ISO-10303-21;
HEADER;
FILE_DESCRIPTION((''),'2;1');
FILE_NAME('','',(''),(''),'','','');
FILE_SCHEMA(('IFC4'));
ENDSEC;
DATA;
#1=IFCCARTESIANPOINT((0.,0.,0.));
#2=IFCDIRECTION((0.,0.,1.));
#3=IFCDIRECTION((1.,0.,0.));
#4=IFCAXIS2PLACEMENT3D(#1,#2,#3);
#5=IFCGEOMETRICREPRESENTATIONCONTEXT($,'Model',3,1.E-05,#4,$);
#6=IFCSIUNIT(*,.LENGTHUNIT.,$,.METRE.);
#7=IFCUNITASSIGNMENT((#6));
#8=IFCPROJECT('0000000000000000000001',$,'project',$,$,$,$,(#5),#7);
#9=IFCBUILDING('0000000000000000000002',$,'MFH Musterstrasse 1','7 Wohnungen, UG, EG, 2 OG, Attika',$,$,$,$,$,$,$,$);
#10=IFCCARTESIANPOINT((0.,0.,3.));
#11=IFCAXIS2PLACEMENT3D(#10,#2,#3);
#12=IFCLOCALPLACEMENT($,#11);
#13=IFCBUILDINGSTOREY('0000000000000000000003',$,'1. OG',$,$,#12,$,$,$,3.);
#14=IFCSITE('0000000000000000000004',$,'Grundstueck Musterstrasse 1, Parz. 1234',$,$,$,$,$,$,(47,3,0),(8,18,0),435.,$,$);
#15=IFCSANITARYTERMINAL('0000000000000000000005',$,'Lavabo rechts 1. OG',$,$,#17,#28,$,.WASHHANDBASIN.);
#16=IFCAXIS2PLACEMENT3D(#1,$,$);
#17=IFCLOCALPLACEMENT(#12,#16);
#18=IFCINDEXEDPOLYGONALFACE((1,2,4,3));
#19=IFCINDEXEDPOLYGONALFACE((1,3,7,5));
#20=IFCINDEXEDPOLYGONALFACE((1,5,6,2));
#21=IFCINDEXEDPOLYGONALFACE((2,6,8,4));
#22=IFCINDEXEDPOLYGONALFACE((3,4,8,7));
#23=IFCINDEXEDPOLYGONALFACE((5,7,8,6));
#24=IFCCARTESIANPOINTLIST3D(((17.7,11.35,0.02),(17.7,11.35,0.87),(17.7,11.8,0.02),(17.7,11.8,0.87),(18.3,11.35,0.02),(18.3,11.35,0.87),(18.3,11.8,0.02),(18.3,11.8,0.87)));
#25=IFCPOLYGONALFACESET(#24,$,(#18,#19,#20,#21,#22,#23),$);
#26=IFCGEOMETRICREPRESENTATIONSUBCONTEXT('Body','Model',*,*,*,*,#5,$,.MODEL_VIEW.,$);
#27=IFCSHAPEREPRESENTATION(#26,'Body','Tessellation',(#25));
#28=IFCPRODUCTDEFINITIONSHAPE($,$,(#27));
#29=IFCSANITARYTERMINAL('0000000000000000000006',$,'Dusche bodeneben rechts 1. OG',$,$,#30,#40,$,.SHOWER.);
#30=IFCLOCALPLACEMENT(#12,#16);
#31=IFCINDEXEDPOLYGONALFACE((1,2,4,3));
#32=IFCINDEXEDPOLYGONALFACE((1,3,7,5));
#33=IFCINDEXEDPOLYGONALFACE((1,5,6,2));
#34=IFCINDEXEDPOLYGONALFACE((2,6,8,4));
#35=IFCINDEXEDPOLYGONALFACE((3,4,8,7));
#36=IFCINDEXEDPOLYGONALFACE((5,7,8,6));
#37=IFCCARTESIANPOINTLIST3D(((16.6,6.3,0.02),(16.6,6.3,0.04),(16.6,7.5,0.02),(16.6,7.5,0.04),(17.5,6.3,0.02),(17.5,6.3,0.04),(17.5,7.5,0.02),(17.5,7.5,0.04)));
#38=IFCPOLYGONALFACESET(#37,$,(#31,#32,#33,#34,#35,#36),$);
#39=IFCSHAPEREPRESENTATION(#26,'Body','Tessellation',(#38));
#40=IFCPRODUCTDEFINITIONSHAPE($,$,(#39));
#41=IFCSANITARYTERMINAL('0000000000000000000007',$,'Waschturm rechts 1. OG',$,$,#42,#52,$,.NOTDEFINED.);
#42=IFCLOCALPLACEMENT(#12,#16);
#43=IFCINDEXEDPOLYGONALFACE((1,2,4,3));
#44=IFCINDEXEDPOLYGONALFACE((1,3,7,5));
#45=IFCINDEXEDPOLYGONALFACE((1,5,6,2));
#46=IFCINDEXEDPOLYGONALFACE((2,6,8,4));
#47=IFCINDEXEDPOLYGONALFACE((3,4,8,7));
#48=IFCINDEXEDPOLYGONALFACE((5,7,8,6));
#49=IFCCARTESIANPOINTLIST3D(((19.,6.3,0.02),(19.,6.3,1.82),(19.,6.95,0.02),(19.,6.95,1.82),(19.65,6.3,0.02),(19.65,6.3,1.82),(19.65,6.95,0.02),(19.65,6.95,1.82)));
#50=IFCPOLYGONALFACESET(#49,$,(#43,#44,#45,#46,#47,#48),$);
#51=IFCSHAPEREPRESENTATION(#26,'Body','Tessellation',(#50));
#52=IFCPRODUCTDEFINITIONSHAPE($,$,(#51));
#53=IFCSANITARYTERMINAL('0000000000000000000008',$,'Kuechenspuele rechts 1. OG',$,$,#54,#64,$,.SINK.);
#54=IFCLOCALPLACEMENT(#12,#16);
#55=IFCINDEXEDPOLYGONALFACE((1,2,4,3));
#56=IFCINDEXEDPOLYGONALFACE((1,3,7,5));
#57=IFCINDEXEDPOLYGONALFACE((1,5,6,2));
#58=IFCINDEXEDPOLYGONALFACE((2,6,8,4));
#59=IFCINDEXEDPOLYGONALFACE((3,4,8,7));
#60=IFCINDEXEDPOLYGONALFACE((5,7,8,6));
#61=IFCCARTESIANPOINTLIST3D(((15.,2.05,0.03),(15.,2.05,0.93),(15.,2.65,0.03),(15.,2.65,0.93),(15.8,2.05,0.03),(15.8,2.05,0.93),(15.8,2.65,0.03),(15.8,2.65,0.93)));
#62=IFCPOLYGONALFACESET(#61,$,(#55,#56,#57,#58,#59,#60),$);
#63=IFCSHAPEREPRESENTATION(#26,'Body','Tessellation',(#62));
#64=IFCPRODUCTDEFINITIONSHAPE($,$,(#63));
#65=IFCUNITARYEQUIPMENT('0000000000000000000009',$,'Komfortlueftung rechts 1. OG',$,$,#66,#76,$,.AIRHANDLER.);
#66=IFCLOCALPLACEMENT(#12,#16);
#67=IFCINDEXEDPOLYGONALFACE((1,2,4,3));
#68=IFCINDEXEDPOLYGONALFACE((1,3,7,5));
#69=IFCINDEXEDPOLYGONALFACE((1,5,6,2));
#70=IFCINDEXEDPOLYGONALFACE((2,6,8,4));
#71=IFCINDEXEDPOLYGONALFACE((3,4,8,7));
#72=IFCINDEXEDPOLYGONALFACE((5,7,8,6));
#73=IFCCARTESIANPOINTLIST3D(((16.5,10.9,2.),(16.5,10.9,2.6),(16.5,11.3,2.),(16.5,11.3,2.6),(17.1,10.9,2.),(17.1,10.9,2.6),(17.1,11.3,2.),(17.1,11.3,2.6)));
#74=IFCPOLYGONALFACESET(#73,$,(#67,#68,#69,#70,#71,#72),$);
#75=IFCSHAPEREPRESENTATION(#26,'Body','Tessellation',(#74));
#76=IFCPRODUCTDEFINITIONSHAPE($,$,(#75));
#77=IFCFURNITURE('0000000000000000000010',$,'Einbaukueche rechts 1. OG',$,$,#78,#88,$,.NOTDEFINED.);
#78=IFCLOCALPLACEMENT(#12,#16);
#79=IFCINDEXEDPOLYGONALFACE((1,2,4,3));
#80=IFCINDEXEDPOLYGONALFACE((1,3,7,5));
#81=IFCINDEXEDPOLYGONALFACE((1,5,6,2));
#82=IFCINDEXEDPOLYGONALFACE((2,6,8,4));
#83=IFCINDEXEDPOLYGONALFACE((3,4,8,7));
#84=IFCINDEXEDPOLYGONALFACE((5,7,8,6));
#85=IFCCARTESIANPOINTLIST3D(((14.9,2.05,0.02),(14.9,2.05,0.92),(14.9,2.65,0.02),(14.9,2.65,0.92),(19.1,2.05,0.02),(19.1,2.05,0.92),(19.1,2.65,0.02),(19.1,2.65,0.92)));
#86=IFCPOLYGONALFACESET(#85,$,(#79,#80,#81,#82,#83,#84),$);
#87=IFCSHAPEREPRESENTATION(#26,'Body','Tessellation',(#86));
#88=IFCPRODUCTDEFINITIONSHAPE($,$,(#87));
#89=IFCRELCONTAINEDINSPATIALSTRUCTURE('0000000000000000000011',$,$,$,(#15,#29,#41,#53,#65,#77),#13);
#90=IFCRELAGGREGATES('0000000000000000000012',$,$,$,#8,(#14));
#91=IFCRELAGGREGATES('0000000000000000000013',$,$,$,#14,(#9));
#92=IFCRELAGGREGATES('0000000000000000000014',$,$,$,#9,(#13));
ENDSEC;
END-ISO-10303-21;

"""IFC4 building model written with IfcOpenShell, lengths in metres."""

from ifc_helpers import new_model, si_unit, frame, frame_2d, origin_with_axes, place, context, subcontext, project, spatial, rectangle, extrude, element, save


model = new_model("IFC4")

# Units and contexts
model_context = context("Model", 3, precision=1e-05, world=origin_with_axes())
body_context = subcontext(model_context, "Body", "Model", "MODEL_VIEW")
ifc_project = project(units=[si_unit("LENGTHUNIT", "METRE")], contexts=[model_context])

# Site, building, storey
site = spatial("IfcSite", under=ifc_project, Name="Grundstueck Musterstrasse 1, Parz. 1234", RefLatitude=(47, 3, 0), RefLongitude=(8, 18, 0), RefElevation=435.0)
building = spatial("IfcBuilding", under=site, Name="MFH Musterstrasse 1", Description="7 Wohnungen, UG, EG, 2 OG, Attika")
storey_placement = place(None, frame((0.0, 0.0, 3.0), z_axis=(0.0, 0.0, 1.0), x_axis=(1.0, 0.0, 0.0)))
storey = spatial("IfcBuildingStorey", under=building, at=storey_placement, Name="1. OG", Elevation=3.0)

# Sanitary terminals
sanitary_terminal_1_placement = place(storey_placement, frame((17.7, 11.35, 0.02), z_axis=(0.0, 0.0, 1.0), x_axis=(1.0, 0.0, 0.0)))
element("IfcSanitaryTerminal", 1, at=sanitary_terminal_1_placement, inside=storey, Name="Lavabo rechts 1. OG", PredefinedType="WASHHANDBASIN", context=body_context, shape_type="SweptSolid", body=[
    extrude(rectangle(XDim=0.6, YDim=0.45, at=frame_2d((0.3, 0.225))), origin_with_axes(), (0.0, 0.0, 1.0), 0.85),
])
sanitary_terminal_2_placement = place(storey_placement, frame((16.6, 6.3, 0.02), z_axis=(0.0, 0.0, 1.0), x_axis=(1.0, 0.0, 0.0)))
element("IfcSanitaryTerminal", 2, at=sanitary_terminal_2_placement, inside=storey, Name="Dusche bodeneben rechts 1. OG", PredefinedType="SHOWER", context=body_context, shape_type="SweptSolid", body=[
    extrude(rectangle(XDim=0.9, YDim=1.2, at=frame_2d((0.45, 0.6))), origin_with_axes(), (0.0, 0.0, 1.0), 0.02),
])
sanitary_terminal_3_placement = place(storey_placement, frame((19.0, 6.3, 0.02), z_axis=(0.0, 0.0, 1.0), x_axis=(1.0, 0.0, 0.0)))
element("IfcSanitaryTerminal", 3, at=sanitary_terminal_3_placement, inside=storey, Name="Waschturm rechts 1. OG", PredefinedType="NOTDEFINED", context=body_context, shape_type="SweptSolid", body=[
    extrude(rectangle(XDim=0.65, YDim=0.65, at=frame_2d((0.325, 0.325))), origin_with_axes(), (0.0, 0.0, 1.0), 1.8),
])
sanitary_terminal_4_placement = place(storey_placement, frame((15.0, 2.05, 0.03), z_axis=(0.0, 0.0, 1.0), x_axis=(1.0, 0.0, 0.0)))
element("IfcSanitaryTerminal", 4, at=sanitary_terminal_4_placement, inside=storey, Name="Kuechenspuele rechts 1. OG", PredefinedType="SINK", context=body_context, shape_type="SweptSolid", body=[
    extrude(rectangle(XDim=0.8, YDim=0.6, at=frame_2d((0.4, 0.3))), origin_with_axes(), (0.0, 0.0, 1.0), 0.9),
])

# Unitary equipment
unitary_equipment_placement = place(storey_placement, frame((16.5, 10.9, 2.0), z_axis=(0.0, 0.0, 1.0), x_axis=(1.0, 0.0, 0.0)))
element("IfcUnitaryEquipment", 5, at=unitary_equipment_placement, inside=storey, Name="Komfortlueftung rechts 1. OG", PredefinedType="AIRHANDLER", context=body_context, shape_type="SweptSolid", body=[
    extrude(rectangle(XDim=0.6, YDim=0.4, at=frame_2d((0.3, 0.2))), origin_with_axes(), (0.0, 0.0, 1.0), 0.6),
])

# Furniture
furniture_placement = place(storey_placement, frame((14.9, 2.05, 0.02), z_axis=(0.0, 0.0, 1.0), x_axis=(1.0, 0.0, 0.0)))
element("IfcFurniture", 6, at=furniture_placement, inside=storey, Name="Einbaukueche rechts 1. OG", PredefinedType="NOTDEFINED", context=body_context, shape_type="SweptSolid", body=[
    extrude(rectangle(XDim=4.2, YDim=0.6, at=frame_2d((2.1, 0.3))), origin_with_axes(), (0.0, 0.0, 1.0), 0.9),
])

save(model, "model.ifc")
